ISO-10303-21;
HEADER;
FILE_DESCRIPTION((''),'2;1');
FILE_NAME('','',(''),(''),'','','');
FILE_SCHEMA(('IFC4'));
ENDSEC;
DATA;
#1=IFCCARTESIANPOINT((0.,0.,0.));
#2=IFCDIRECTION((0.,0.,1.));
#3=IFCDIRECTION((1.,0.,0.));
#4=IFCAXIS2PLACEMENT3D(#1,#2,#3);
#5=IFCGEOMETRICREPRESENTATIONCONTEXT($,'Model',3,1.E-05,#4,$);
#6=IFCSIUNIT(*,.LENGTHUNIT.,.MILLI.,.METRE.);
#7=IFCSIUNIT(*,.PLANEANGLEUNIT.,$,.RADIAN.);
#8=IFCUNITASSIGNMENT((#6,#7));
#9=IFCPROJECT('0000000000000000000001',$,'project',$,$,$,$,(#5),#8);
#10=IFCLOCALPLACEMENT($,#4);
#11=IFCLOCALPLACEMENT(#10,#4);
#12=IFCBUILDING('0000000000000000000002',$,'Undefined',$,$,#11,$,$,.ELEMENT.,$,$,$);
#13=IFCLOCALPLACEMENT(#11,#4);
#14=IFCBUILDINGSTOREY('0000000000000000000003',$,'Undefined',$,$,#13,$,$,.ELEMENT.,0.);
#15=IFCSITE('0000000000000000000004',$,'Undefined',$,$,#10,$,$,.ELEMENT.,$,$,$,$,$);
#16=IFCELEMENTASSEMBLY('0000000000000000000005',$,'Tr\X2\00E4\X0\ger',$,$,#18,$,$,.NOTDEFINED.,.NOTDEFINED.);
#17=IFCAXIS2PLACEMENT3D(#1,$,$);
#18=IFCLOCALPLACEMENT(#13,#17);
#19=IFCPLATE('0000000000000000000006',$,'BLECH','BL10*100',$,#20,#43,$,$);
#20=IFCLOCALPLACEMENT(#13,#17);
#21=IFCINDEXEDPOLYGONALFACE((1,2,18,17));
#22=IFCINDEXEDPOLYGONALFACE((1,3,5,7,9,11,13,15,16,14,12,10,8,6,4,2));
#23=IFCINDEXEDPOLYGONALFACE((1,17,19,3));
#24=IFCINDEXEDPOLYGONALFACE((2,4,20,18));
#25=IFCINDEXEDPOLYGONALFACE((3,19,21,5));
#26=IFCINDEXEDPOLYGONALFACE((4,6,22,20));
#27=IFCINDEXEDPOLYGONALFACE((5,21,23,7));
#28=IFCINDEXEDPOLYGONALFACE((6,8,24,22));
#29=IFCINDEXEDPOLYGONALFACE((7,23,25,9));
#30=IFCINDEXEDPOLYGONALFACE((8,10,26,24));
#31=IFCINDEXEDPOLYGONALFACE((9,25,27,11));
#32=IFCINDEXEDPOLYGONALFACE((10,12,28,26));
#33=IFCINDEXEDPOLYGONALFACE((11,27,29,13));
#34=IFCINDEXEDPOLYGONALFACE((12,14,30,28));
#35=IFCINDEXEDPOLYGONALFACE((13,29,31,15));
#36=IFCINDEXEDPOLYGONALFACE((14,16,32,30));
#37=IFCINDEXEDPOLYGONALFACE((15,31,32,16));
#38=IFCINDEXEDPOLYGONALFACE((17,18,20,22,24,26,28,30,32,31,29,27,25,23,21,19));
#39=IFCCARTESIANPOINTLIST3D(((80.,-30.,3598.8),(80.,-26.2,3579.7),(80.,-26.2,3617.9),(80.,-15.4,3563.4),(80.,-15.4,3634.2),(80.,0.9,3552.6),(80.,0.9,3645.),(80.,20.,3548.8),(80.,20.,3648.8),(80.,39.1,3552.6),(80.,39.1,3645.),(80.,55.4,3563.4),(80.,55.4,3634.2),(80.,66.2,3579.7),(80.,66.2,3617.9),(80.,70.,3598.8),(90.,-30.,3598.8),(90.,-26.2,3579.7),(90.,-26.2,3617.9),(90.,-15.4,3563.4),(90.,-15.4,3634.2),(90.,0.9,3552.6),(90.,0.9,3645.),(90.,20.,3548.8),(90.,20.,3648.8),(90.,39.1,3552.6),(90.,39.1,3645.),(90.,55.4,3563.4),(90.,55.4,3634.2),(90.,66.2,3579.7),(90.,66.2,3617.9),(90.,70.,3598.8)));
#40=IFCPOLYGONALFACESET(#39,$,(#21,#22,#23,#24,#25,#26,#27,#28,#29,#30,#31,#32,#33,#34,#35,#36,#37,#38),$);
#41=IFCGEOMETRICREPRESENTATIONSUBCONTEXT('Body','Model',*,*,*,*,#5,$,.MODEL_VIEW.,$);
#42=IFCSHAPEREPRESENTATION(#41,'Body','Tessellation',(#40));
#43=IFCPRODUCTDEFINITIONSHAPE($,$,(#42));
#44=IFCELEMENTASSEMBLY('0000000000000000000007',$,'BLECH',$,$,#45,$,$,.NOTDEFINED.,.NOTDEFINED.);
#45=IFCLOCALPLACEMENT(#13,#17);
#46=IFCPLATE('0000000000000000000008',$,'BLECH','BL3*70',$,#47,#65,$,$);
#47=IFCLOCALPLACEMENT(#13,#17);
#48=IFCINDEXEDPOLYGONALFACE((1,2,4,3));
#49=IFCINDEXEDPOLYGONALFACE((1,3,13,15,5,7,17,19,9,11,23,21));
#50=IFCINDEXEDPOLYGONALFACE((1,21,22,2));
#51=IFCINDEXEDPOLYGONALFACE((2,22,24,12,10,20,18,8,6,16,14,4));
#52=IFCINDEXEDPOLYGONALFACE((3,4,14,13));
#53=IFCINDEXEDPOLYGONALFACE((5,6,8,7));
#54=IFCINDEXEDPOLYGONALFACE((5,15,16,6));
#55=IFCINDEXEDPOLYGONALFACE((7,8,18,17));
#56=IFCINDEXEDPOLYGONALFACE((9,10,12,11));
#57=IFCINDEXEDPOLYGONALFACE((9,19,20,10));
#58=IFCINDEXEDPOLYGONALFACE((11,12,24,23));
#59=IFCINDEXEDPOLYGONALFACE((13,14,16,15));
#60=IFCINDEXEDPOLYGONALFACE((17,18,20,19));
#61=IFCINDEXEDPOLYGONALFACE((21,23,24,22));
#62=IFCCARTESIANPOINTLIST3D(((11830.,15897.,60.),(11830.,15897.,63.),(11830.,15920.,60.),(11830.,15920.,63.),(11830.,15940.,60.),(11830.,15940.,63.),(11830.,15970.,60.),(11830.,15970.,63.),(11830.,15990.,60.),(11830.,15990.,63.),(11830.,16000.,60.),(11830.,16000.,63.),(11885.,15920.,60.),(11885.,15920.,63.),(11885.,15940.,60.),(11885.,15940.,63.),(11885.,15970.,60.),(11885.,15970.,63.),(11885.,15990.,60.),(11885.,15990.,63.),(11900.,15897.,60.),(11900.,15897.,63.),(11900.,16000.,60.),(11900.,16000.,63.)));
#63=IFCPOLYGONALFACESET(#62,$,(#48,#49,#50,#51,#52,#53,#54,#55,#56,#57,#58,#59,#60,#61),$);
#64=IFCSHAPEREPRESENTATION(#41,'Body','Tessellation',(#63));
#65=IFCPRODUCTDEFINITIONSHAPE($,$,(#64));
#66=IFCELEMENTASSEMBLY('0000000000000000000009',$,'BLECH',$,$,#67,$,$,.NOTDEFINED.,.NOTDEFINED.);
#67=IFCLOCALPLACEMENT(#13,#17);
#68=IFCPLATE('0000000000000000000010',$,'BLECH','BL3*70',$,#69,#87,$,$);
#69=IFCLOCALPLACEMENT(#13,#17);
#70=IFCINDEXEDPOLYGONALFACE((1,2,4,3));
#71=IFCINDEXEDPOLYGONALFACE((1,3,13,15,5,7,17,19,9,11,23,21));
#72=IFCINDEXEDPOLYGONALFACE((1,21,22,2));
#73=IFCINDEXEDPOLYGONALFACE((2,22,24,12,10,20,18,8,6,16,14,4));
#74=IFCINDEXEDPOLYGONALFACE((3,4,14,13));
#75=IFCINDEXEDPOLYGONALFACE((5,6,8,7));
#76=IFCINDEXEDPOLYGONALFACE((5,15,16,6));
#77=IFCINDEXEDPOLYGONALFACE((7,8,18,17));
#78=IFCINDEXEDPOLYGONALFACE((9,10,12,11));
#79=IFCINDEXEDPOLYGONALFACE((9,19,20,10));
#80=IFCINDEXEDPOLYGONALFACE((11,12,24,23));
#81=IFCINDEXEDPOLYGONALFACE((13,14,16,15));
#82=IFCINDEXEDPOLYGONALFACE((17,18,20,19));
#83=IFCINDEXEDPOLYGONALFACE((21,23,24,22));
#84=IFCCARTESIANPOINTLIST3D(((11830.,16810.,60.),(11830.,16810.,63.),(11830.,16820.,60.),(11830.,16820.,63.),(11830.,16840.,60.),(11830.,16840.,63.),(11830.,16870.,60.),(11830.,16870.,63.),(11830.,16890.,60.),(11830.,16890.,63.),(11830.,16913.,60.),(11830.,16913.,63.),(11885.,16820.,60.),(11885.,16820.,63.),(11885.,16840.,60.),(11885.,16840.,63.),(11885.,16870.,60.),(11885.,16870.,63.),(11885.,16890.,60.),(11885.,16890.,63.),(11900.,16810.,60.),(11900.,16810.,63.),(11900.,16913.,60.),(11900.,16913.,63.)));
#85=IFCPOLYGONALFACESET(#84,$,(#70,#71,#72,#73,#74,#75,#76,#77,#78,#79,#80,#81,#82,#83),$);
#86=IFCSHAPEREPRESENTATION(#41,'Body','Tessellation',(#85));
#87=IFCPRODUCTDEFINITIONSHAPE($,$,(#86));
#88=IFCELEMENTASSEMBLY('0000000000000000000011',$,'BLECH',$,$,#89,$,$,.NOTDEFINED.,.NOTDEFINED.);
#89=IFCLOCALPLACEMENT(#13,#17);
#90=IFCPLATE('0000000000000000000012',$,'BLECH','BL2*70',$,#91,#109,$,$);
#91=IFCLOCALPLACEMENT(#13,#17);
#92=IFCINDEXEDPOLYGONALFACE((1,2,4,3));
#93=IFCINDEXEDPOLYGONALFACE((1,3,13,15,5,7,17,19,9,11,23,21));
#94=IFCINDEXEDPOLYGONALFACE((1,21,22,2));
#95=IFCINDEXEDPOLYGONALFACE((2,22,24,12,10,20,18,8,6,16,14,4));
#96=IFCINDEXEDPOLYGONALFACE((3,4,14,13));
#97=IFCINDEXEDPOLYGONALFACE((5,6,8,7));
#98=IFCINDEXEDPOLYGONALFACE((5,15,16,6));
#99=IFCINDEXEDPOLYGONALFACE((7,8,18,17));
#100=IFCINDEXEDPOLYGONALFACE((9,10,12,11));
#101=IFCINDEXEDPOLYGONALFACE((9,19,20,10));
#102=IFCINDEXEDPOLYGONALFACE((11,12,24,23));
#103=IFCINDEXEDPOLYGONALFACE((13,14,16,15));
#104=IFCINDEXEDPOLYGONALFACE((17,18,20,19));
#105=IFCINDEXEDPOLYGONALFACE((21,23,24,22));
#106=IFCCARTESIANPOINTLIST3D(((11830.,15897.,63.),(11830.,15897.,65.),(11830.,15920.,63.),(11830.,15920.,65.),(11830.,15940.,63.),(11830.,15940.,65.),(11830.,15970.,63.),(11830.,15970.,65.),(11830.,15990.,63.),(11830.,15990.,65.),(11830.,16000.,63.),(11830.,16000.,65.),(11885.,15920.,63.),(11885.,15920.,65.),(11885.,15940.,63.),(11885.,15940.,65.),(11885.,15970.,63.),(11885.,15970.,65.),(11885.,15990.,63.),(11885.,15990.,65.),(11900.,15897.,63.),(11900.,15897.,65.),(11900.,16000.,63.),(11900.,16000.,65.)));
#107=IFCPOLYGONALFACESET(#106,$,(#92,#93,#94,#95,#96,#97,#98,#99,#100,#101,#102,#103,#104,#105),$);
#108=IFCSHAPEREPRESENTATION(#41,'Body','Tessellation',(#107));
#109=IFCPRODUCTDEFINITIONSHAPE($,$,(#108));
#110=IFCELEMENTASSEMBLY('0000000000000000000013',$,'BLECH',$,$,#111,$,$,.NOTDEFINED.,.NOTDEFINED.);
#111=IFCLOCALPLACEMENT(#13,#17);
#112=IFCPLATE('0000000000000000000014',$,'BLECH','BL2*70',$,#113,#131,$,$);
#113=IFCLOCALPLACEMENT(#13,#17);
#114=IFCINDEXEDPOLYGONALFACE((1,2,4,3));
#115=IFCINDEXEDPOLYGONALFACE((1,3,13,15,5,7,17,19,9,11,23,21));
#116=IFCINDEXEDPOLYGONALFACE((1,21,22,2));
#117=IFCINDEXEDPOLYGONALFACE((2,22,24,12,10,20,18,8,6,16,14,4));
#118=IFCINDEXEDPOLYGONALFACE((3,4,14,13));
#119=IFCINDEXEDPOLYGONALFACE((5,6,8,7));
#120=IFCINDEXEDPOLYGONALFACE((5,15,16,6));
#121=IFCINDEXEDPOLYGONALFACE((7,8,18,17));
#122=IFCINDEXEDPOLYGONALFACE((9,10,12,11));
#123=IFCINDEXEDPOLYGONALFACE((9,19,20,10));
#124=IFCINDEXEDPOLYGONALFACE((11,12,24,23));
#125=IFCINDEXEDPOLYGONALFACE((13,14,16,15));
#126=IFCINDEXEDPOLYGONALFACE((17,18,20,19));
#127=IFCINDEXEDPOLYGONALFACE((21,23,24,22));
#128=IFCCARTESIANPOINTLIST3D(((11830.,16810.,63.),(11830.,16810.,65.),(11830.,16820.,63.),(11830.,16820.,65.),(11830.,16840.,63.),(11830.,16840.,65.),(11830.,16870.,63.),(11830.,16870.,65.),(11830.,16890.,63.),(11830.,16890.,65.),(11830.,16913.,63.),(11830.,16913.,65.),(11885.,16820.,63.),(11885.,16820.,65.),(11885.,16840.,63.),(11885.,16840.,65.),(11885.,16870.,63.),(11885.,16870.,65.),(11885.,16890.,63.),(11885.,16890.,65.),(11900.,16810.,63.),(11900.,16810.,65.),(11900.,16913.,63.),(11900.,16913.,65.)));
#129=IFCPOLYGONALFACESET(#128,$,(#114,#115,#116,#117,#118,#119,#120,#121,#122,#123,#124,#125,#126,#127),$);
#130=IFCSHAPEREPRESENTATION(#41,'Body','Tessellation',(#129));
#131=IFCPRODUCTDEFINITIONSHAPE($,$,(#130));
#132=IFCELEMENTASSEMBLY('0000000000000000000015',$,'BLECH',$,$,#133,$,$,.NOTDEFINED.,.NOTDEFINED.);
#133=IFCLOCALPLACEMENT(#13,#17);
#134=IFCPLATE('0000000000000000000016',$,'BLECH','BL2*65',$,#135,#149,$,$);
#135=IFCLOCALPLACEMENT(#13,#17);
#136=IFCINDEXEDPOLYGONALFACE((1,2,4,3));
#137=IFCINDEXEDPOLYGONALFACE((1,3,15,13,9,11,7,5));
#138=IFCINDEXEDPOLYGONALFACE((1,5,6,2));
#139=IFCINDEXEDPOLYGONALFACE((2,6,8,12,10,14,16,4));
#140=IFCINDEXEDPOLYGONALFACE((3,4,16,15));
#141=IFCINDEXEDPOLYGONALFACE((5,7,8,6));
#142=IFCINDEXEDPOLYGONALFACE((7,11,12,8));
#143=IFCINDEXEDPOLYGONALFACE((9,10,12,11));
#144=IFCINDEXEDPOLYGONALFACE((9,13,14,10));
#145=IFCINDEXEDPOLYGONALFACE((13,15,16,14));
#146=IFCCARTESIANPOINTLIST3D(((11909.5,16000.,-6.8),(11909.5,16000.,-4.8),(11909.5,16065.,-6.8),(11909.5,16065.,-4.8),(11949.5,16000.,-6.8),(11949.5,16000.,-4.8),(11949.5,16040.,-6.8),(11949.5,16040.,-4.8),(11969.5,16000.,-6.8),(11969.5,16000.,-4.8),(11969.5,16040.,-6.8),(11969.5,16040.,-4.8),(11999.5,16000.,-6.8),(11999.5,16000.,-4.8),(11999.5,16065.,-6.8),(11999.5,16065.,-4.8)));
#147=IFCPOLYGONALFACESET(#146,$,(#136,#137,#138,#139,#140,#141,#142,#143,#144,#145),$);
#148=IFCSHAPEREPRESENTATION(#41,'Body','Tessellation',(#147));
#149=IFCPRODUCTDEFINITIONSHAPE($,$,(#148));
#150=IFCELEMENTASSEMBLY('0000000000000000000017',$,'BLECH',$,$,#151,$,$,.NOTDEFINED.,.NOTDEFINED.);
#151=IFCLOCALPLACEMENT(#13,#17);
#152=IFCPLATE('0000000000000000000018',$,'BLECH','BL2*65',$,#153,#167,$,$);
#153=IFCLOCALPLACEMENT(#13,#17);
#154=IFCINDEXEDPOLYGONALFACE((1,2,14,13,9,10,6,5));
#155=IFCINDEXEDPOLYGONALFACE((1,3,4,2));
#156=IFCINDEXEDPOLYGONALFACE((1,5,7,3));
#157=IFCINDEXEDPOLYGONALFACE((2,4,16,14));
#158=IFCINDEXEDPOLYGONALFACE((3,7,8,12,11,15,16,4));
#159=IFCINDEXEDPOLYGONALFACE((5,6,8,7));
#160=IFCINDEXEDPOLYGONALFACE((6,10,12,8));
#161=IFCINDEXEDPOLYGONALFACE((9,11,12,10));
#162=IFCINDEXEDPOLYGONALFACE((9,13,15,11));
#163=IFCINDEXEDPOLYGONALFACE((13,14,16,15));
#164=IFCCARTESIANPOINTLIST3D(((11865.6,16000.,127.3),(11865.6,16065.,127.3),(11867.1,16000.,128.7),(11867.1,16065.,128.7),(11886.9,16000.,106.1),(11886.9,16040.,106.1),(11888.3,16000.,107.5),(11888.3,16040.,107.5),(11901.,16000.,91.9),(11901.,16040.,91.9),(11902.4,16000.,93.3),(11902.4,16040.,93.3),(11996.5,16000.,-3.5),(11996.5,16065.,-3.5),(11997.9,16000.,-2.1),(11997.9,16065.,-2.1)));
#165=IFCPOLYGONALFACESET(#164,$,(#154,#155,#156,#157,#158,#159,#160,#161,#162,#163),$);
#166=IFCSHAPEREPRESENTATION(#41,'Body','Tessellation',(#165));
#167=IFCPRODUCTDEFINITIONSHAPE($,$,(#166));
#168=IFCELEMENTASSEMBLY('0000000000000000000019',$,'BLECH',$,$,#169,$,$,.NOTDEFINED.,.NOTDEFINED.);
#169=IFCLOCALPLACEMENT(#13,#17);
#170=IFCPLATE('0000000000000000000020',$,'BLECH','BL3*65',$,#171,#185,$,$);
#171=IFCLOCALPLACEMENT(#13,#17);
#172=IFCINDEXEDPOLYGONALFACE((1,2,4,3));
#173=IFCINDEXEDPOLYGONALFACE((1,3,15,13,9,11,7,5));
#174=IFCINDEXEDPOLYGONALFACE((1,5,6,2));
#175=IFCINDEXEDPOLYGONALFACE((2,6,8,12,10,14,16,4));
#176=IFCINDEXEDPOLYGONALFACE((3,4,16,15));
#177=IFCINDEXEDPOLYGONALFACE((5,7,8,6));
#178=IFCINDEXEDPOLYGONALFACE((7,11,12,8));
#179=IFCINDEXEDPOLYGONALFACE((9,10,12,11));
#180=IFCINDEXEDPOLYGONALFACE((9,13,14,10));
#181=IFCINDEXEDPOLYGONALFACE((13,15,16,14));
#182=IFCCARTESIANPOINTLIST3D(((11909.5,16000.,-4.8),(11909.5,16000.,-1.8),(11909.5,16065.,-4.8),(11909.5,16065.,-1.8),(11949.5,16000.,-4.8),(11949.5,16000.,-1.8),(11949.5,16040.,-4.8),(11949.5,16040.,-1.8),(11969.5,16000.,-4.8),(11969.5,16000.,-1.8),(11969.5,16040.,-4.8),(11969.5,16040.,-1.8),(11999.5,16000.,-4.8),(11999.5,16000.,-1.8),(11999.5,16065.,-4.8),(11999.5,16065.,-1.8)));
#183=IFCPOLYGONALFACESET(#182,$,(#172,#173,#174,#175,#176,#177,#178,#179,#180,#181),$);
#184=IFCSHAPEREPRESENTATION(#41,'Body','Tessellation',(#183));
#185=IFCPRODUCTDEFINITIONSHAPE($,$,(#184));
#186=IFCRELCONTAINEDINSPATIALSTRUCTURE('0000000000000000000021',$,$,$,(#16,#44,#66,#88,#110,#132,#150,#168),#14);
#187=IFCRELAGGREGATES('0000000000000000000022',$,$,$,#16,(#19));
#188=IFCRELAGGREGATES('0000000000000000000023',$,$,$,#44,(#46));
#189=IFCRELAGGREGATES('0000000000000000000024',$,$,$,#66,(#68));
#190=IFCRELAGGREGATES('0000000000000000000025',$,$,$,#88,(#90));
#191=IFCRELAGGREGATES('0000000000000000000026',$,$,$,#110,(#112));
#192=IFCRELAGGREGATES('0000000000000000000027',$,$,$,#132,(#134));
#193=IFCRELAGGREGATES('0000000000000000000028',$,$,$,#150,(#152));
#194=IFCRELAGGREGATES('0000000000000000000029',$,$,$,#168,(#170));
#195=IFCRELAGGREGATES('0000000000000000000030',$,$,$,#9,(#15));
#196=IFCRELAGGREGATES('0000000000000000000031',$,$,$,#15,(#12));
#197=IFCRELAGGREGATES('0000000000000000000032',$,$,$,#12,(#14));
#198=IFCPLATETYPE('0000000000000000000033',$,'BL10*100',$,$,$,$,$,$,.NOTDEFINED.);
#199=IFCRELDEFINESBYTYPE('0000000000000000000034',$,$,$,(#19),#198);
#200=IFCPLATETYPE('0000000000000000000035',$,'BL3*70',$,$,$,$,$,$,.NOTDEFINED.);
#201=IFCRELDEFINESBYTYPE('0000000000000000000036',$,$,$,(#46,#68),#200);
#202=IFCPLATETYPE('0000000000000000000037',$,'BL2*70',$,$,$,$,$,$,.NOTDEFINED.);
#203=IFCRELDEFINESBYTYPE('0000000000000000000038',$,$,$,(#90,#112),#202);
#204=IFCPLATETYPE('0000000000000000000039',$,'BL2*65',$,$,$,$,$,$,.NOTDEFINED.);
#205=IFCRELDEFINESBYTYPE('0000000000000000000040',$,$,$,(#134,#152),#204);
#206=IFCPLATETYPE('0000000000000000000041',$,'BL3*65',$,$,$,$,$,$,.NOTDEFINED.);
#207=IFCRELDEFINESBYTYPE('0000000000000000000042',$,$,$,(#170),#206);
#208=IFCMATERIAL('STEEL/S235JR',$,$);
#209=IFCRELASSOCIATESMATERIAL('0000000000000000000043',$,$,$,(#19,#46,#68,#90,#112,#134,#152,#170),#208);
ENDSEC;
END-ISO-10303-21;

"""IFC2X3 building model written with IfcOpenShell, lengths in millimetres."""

from ifc_helpers import new_model, si_unit, frame, origin_with_axes, place, context, subcontext, project, spatial, polyline, outline, extrude, material, type_object, element, aggregate, save


model = new_model("IFC2X3")

# Units and contexts
model_context = context("Model", 3, precision=1e-05, world=origin_with_axes())
body_context = subcontext(model_context, "Body", "Model", "MODEL_VIEW")
ifc_project = project(units=[si_unit("LENGTHUNIT", "METRE", prefix="MILLI"), si_unit("PLANEANGLEUNIT", "RADIAN")], contexts=[model_context])

# Site, building, storey
site_placement = place(None, origin_with_axes())
site = spatial("IfcSite", under=ifc_project, at=site_placement, Name="Undefined", CompositionType="ELEMENT")
building_placement = place(site_placement, origin_with_axes())
building = spatial("IfcBuilding", under=site, at=building_placement, Name="Undefined", CompositionType="ELEMENT")
storey_placement = place(building_placement, origin_with_axes())
storey = spatial("IfcBuildingStorey", under=building, at=storey_placement, Name="Undefined", CompositionType="ELEMENT", Elevation=0.0)

# Shared definitions
ifc_material = material(Name="STEEL/S235JR")

# Element assembly
assembly_1_placement = place(storey_placement, origin_with_axes())
assembly_1 = element("IfcElementAssembly", 1, at=assembly_1_placement, inside=storey, Name="Träger", AssemblyPlace="NOTDEFINED", PredefinedType="NOTDEFINED")

# Plate
plate_type_1 = type_object("IfcPlateType", Name="BL10*100", PredefinedType="NOTDEFINED")
plate_1_placement = place(assembly_1_placement, frame((85.0, 70.0, 3648.8), z_axis=(1.0, 0.0, 0.0), x_axis=(0.0, -1.0, 0.0)))
plate_1 = element("IfcPlate", 2, at=plate_1_placement, type_object=plate_type_1, material=ifc_material, Name="BLECH", Description="BL10*100", context=body_context, shape_type="SweptSolid", body=[
    extrude(outline(polyline([(0.0, 50.0), (3.8, 30.9), (14.6, 14.6), (30.9, 3.8), (50.0, 0.0), (50.0, 0.0), (69.1, 3.8), (85.4, 14.6), (96.2, 30.9), (100.0, 50.0), (100.0, 50.0), (96.2, 69.1), (85.4, 85.4), (69.1, 96.2), (50.0, 100.0), (50.0, 100.0), (30.9, 96.2), (14.6, 85.4), (3.8, 69.1), (0.0, 50.0), (0.0, 50.0)])), frame((0.0, 0.0, -5.0), z_axis=(0.0, 0.0, 1.0), x_axis=(1.0, 0.0, 0.0)), (0.0, 0.0, 1.0), 10.0),
])
aggregate(assembly_1, [plate_1])

# Element assemblies, plates
assembly_2_placement = place(storey_placement, origin_with_axes())
assembly_2 = element("IfcElementAssembly", 3, at=assembly_2_placement, inside=storey, Name="BLECH", AssemblyPlace="NOTDEFINED", PredefinedType="NOTDEFINED")
plate_type_2 = type_object("IfcPlateType", Name="BL3*70", PredefinedType="NOTDEFINED")
plate_2_placement = place(assembly_2_placement, frame((11830.0, 16000.0, 61.5), z_axis=(0.0, 0.0, -1.0), x_axis=(1.0, 0.0, 0.0)))
plate_2 = element("IfcPlate", 4, at=plate_2_placement, type_object=plate_type_2, material=ifc_material, Name="BLECH", Description="BL3*70", context=body_context, shape_type="SweptSolid", body=[
    extrude(outline(polyline([(0.0, 0.0), (70.0, 0.0), (70.0, 103.0), (0.0, 103.0), (0.0, 80.0), (55.0, 80.0), (55.0, 60.0), (0.0, 60.0), (0.0, 30.0), (55.0, 30.0), (55.0, 10.0), (0.0, 10.0), (0.0, 0.0)])), frame((0.0, 0.0, -1.5), z_axis=(0.0, 0.0, 1.0), x_axis=(1.0, 0.0, 0.0)), (0.0, 0.0, 1.0), 3.0),
])
aggregate(assembly_2, [plate_2])
assembly_3_placement = place(storey_placement, origin_with_axes())
assembly_3 = element("IfcElementAssembly", 5, at=assembly_3_placement, inside=storey, Name="BLECH", AssemblyPlace="NOTDEFINED", PredefinedType="NOTDEFINED")
plate_3_placement = place(assembly_3_placement, frame((11830.0, 16810.0, 61.5), z_axis=(0.0, 0.0, 1.0), x_axis=(1.0, 0.000009, 0.0)))
plate_3 = element("IfcPlate", 6, at=plate_3_placement, type_object=plate_type_2, material=ifc_material, Name="BLECH", Description="BL3*70", context=body_context, shape_type="SweptSolid", body=[
    extrude(outline(polyline([(0.0, 0.0), (70.0, 0.0), (70.0, 103.0), (0.0, 103.0), (0.0, 80.0), (55.0, 80.0), (55.0, 60.0), (0.0, 60.0), (0.0, 30.0), (55.0, 30.0), (55.0, 10.0), (0.0, 10.0), (0.0, 0.0)])), frame((0.0, 0.0, -1.5), z_axis=(0.0, 0.0, 1.0), x_axis=(1.0, 0.0, 0.0)), (0.0, 0.0, 1.0), 3.0),
])
aggregate(assembly_3, [plate_3])
assembly_4_placement = place(storey_placement, origin_with_axes())
assembly_4 = element("IfcElementAssembly", 7, at=assembly_4_placement, inside=storey, Name="BLECH", AssemblyPlace="NOTDEFINED", PredefinedType="NOTDEFINED")
plate_type_3 = type_object("IfcPlateType", Name="BL2*70", PredefinedType="NOTDEFINED")
plate_4_placement = place(assembly_4_placement, frame((11830.0, 16000.0, 64.0), z_axis=(0.0, 0.0, -1.0), x_axis=(1.0, 0.0, 0.0)))
plate_4 = element("IfcPlate", 8, at=plate_4_placement, type_object=plate_type_3, material=ifc_material, Name="BLECH", Description="BL2*70", context=body_context, shape_type="SweptSolid", body=[
    extrude(outline(polyline([(0.0, 0.0), (70.0, 0.0), (70.0, 103.0), (0.0, 103.0), (0.0, 80.0), (55.0, 80.0), (55.0, 60.0), (0.0, 60.0), (0.0, 30.0), (55.0, 30.0), (55.0, 10.0), (0.0, 10.0), (0.0, 0.0)])), frame((0.0, 0.0, -1.0), z_axis=(0.0, 0.0, 1.0), x_axis=(1.0, 0.0, 0.0)), (0.0, 0.0, 1.0), 2.0),
])
aggregate(assembly_4, [plate_4])
assembly_5_placement = place(storey_placement, origin_with_axes())
assembly_5 = element("IfcElementAssembly", 9, at=assembly_5_placement, inside=storey, Name="BLECH", AssemblyPlace="NOTDEFINED", PredefinedType="NOTDEFINED")
plate_5_placement = place(assembly_5_placement, frame((11830.0, 16810.0, 64.0), z_axis=(0.0, 0.0, 1.0), x_axis=(1.0, 0.000009, 0.0)))
plate_5 = element("IfcPlate", 10, at=plate_5_placement, type_object=plate_type_3, material=ifc_material, Name="BLECH", Description="BL2*70", context=body_context, shape_type="SweptSolid", body=[
    extrude(outline(polyline([(0.0, 0.0), (70.0, 0.0), (70.0, 103.0), (0.0, 103.0), (0.0, 80.0), (55.0, 80.0), (55.0, 60.0), (0.0, 60.0), (0.0, 30.0), (55.0, 30.0), (55.0, 10.0), (0.0, 10.0), (0.0, 0.0)])), frame((0.0, 0.0, -1.0), z_axis=(0.0, 0.0, 1.0), x_axis=(1.0, 0.0, 0.0)), (0.0, 0.0, 1.0), 2.0),
])
aggregate(assembly_5, [plate_5])
assembly_6_placement = place(storey_placement, origin_with_axes())
assembly_6 = element("IfcElementAssembly", 11, at=assembly_6_placement, inside=storey, Name="BLECH", AssemblyPlace="NOTDEFINED", PredefinedType="NOTDEFINED")
plate_type_4 = type_object("IfcPlateType", Name="BL2*65", PredefinedType="NOTDEFINED")
plate_6_placement = place(assembly_6_placement, frame((11999.5, 16000.0, -5.8), z_axis=(0.0, 0.0, 1.0), x_axis=(0.0, 1.0, 0.0)))
plate_6 = element("IfcPlate", 12, at=plate_6_placement, type_object=plate_type_4, material=ifc_material, Name="BLECH", Description="BL2*65", context=body_context, shape_type="SweptSolid", body=[
    extrude(outline(polyline([(0.0, 0.0), (65.0, 0.0), (65.0, 90.0), (0.0, 90.0), (0.0, 50.0), (40.0, 50.0), (40.0, 30.0), (0.0, 30.0), (0.0, 0.0)])), frame((0.0, 0.0, -1.0), z_axis=(0.0, 0.0, 1.0), x_axis=(1.0, 0.0, 0.0)), (0.0, 0.0, 1.0), 2.0),
])
aggregate(assembly_6, [plate_6])
assembly_7_placement = place(storey_placement, origin_with_axes())
assembly_7 = element("IfcElementAssembly", 13, at=assembly_7_placement, inside=storey, Name="BLECH", AssemblyPlace="NOTDEFINED", PredefinedType="NOTDEFINED")
plate_7_placement = place(assembly_7_placement, frame((11997.2, 16065.0, -2.8), z_axis=(0.707107, 0.0, 0.707107), x_axis=(-0.707107, 0.0, 0.707107)))
plate_7 = element("IfcPlate", 14, at=plate_7_placement, type_object=plate_type_4, material=ifc_material, Name="BLECH", Description="BL2*65", context=body_context, shape_type="SweptSolid", body=[
    extrude(outline(polyline([(0.0, 0.0), (185.0, 0.0), (185.0, 65.0), (155.0, 65.0), (155.0, 25.0), (135.0, 25.0), (135.0, 65.0), (0.0, 65.0), (0.0, 0.0)])), frame((0.0, 0.0, -1.0), z_axis=(0.0, 0.0, 1.0), x_axis=(1.0, 0.0, 0.0)), (0.0, 0.0, 1.0), 2.0),
])
aggregate(assembly_7, [plate_7])
assembly_8_placement = place(storey_placement, origin_with_axes())
assembly_8 = element("IfcElementAssembly", 15, at=assembly_8_placement, inside=storey, Name="BLECH", AssemblyPlace="NOTDEFINED", PredefinedType="NOTDEFINED")
plate_type_5 = type_object("IfcPlateType", Name="BL3*65", PredefinedType="NOTDEFINED")
plate_8_placement = place(assembly_8_placement, frame((11999.5, 16000.0, -3.3), z_axis=(0.0, 0.0, 1.0), x_axis=(0.0, 1.0, 0.0)))
plate_8 = element("IfcPlate", 16, at=plate_8_placement, type_object=plate_type_5, material=ifc_material, Name="BLECH", Description="BL3*65", context=body_context, shape_type="SweptSolid", body=[
    extrude(outline(polyline([(0.0, 0.0), (65.0, 0.0), (65.0, 90.0), (0.0, 90.0), (0.0, 50.0), (40.0, 50.0), (40.0, 30.0), (0.0, 30.0), (0.0, 0.0)])), frame((0.0, 0.0, -1.5), z_axis=(0.0, 0.0, 1.0), x_axis=(1.0, 0.0, 0.0)), (0.0, 0.0, 1.0), 3.0),
])
aggregate(assembly_8, [plate_8])

save(model, "model.ifc")
